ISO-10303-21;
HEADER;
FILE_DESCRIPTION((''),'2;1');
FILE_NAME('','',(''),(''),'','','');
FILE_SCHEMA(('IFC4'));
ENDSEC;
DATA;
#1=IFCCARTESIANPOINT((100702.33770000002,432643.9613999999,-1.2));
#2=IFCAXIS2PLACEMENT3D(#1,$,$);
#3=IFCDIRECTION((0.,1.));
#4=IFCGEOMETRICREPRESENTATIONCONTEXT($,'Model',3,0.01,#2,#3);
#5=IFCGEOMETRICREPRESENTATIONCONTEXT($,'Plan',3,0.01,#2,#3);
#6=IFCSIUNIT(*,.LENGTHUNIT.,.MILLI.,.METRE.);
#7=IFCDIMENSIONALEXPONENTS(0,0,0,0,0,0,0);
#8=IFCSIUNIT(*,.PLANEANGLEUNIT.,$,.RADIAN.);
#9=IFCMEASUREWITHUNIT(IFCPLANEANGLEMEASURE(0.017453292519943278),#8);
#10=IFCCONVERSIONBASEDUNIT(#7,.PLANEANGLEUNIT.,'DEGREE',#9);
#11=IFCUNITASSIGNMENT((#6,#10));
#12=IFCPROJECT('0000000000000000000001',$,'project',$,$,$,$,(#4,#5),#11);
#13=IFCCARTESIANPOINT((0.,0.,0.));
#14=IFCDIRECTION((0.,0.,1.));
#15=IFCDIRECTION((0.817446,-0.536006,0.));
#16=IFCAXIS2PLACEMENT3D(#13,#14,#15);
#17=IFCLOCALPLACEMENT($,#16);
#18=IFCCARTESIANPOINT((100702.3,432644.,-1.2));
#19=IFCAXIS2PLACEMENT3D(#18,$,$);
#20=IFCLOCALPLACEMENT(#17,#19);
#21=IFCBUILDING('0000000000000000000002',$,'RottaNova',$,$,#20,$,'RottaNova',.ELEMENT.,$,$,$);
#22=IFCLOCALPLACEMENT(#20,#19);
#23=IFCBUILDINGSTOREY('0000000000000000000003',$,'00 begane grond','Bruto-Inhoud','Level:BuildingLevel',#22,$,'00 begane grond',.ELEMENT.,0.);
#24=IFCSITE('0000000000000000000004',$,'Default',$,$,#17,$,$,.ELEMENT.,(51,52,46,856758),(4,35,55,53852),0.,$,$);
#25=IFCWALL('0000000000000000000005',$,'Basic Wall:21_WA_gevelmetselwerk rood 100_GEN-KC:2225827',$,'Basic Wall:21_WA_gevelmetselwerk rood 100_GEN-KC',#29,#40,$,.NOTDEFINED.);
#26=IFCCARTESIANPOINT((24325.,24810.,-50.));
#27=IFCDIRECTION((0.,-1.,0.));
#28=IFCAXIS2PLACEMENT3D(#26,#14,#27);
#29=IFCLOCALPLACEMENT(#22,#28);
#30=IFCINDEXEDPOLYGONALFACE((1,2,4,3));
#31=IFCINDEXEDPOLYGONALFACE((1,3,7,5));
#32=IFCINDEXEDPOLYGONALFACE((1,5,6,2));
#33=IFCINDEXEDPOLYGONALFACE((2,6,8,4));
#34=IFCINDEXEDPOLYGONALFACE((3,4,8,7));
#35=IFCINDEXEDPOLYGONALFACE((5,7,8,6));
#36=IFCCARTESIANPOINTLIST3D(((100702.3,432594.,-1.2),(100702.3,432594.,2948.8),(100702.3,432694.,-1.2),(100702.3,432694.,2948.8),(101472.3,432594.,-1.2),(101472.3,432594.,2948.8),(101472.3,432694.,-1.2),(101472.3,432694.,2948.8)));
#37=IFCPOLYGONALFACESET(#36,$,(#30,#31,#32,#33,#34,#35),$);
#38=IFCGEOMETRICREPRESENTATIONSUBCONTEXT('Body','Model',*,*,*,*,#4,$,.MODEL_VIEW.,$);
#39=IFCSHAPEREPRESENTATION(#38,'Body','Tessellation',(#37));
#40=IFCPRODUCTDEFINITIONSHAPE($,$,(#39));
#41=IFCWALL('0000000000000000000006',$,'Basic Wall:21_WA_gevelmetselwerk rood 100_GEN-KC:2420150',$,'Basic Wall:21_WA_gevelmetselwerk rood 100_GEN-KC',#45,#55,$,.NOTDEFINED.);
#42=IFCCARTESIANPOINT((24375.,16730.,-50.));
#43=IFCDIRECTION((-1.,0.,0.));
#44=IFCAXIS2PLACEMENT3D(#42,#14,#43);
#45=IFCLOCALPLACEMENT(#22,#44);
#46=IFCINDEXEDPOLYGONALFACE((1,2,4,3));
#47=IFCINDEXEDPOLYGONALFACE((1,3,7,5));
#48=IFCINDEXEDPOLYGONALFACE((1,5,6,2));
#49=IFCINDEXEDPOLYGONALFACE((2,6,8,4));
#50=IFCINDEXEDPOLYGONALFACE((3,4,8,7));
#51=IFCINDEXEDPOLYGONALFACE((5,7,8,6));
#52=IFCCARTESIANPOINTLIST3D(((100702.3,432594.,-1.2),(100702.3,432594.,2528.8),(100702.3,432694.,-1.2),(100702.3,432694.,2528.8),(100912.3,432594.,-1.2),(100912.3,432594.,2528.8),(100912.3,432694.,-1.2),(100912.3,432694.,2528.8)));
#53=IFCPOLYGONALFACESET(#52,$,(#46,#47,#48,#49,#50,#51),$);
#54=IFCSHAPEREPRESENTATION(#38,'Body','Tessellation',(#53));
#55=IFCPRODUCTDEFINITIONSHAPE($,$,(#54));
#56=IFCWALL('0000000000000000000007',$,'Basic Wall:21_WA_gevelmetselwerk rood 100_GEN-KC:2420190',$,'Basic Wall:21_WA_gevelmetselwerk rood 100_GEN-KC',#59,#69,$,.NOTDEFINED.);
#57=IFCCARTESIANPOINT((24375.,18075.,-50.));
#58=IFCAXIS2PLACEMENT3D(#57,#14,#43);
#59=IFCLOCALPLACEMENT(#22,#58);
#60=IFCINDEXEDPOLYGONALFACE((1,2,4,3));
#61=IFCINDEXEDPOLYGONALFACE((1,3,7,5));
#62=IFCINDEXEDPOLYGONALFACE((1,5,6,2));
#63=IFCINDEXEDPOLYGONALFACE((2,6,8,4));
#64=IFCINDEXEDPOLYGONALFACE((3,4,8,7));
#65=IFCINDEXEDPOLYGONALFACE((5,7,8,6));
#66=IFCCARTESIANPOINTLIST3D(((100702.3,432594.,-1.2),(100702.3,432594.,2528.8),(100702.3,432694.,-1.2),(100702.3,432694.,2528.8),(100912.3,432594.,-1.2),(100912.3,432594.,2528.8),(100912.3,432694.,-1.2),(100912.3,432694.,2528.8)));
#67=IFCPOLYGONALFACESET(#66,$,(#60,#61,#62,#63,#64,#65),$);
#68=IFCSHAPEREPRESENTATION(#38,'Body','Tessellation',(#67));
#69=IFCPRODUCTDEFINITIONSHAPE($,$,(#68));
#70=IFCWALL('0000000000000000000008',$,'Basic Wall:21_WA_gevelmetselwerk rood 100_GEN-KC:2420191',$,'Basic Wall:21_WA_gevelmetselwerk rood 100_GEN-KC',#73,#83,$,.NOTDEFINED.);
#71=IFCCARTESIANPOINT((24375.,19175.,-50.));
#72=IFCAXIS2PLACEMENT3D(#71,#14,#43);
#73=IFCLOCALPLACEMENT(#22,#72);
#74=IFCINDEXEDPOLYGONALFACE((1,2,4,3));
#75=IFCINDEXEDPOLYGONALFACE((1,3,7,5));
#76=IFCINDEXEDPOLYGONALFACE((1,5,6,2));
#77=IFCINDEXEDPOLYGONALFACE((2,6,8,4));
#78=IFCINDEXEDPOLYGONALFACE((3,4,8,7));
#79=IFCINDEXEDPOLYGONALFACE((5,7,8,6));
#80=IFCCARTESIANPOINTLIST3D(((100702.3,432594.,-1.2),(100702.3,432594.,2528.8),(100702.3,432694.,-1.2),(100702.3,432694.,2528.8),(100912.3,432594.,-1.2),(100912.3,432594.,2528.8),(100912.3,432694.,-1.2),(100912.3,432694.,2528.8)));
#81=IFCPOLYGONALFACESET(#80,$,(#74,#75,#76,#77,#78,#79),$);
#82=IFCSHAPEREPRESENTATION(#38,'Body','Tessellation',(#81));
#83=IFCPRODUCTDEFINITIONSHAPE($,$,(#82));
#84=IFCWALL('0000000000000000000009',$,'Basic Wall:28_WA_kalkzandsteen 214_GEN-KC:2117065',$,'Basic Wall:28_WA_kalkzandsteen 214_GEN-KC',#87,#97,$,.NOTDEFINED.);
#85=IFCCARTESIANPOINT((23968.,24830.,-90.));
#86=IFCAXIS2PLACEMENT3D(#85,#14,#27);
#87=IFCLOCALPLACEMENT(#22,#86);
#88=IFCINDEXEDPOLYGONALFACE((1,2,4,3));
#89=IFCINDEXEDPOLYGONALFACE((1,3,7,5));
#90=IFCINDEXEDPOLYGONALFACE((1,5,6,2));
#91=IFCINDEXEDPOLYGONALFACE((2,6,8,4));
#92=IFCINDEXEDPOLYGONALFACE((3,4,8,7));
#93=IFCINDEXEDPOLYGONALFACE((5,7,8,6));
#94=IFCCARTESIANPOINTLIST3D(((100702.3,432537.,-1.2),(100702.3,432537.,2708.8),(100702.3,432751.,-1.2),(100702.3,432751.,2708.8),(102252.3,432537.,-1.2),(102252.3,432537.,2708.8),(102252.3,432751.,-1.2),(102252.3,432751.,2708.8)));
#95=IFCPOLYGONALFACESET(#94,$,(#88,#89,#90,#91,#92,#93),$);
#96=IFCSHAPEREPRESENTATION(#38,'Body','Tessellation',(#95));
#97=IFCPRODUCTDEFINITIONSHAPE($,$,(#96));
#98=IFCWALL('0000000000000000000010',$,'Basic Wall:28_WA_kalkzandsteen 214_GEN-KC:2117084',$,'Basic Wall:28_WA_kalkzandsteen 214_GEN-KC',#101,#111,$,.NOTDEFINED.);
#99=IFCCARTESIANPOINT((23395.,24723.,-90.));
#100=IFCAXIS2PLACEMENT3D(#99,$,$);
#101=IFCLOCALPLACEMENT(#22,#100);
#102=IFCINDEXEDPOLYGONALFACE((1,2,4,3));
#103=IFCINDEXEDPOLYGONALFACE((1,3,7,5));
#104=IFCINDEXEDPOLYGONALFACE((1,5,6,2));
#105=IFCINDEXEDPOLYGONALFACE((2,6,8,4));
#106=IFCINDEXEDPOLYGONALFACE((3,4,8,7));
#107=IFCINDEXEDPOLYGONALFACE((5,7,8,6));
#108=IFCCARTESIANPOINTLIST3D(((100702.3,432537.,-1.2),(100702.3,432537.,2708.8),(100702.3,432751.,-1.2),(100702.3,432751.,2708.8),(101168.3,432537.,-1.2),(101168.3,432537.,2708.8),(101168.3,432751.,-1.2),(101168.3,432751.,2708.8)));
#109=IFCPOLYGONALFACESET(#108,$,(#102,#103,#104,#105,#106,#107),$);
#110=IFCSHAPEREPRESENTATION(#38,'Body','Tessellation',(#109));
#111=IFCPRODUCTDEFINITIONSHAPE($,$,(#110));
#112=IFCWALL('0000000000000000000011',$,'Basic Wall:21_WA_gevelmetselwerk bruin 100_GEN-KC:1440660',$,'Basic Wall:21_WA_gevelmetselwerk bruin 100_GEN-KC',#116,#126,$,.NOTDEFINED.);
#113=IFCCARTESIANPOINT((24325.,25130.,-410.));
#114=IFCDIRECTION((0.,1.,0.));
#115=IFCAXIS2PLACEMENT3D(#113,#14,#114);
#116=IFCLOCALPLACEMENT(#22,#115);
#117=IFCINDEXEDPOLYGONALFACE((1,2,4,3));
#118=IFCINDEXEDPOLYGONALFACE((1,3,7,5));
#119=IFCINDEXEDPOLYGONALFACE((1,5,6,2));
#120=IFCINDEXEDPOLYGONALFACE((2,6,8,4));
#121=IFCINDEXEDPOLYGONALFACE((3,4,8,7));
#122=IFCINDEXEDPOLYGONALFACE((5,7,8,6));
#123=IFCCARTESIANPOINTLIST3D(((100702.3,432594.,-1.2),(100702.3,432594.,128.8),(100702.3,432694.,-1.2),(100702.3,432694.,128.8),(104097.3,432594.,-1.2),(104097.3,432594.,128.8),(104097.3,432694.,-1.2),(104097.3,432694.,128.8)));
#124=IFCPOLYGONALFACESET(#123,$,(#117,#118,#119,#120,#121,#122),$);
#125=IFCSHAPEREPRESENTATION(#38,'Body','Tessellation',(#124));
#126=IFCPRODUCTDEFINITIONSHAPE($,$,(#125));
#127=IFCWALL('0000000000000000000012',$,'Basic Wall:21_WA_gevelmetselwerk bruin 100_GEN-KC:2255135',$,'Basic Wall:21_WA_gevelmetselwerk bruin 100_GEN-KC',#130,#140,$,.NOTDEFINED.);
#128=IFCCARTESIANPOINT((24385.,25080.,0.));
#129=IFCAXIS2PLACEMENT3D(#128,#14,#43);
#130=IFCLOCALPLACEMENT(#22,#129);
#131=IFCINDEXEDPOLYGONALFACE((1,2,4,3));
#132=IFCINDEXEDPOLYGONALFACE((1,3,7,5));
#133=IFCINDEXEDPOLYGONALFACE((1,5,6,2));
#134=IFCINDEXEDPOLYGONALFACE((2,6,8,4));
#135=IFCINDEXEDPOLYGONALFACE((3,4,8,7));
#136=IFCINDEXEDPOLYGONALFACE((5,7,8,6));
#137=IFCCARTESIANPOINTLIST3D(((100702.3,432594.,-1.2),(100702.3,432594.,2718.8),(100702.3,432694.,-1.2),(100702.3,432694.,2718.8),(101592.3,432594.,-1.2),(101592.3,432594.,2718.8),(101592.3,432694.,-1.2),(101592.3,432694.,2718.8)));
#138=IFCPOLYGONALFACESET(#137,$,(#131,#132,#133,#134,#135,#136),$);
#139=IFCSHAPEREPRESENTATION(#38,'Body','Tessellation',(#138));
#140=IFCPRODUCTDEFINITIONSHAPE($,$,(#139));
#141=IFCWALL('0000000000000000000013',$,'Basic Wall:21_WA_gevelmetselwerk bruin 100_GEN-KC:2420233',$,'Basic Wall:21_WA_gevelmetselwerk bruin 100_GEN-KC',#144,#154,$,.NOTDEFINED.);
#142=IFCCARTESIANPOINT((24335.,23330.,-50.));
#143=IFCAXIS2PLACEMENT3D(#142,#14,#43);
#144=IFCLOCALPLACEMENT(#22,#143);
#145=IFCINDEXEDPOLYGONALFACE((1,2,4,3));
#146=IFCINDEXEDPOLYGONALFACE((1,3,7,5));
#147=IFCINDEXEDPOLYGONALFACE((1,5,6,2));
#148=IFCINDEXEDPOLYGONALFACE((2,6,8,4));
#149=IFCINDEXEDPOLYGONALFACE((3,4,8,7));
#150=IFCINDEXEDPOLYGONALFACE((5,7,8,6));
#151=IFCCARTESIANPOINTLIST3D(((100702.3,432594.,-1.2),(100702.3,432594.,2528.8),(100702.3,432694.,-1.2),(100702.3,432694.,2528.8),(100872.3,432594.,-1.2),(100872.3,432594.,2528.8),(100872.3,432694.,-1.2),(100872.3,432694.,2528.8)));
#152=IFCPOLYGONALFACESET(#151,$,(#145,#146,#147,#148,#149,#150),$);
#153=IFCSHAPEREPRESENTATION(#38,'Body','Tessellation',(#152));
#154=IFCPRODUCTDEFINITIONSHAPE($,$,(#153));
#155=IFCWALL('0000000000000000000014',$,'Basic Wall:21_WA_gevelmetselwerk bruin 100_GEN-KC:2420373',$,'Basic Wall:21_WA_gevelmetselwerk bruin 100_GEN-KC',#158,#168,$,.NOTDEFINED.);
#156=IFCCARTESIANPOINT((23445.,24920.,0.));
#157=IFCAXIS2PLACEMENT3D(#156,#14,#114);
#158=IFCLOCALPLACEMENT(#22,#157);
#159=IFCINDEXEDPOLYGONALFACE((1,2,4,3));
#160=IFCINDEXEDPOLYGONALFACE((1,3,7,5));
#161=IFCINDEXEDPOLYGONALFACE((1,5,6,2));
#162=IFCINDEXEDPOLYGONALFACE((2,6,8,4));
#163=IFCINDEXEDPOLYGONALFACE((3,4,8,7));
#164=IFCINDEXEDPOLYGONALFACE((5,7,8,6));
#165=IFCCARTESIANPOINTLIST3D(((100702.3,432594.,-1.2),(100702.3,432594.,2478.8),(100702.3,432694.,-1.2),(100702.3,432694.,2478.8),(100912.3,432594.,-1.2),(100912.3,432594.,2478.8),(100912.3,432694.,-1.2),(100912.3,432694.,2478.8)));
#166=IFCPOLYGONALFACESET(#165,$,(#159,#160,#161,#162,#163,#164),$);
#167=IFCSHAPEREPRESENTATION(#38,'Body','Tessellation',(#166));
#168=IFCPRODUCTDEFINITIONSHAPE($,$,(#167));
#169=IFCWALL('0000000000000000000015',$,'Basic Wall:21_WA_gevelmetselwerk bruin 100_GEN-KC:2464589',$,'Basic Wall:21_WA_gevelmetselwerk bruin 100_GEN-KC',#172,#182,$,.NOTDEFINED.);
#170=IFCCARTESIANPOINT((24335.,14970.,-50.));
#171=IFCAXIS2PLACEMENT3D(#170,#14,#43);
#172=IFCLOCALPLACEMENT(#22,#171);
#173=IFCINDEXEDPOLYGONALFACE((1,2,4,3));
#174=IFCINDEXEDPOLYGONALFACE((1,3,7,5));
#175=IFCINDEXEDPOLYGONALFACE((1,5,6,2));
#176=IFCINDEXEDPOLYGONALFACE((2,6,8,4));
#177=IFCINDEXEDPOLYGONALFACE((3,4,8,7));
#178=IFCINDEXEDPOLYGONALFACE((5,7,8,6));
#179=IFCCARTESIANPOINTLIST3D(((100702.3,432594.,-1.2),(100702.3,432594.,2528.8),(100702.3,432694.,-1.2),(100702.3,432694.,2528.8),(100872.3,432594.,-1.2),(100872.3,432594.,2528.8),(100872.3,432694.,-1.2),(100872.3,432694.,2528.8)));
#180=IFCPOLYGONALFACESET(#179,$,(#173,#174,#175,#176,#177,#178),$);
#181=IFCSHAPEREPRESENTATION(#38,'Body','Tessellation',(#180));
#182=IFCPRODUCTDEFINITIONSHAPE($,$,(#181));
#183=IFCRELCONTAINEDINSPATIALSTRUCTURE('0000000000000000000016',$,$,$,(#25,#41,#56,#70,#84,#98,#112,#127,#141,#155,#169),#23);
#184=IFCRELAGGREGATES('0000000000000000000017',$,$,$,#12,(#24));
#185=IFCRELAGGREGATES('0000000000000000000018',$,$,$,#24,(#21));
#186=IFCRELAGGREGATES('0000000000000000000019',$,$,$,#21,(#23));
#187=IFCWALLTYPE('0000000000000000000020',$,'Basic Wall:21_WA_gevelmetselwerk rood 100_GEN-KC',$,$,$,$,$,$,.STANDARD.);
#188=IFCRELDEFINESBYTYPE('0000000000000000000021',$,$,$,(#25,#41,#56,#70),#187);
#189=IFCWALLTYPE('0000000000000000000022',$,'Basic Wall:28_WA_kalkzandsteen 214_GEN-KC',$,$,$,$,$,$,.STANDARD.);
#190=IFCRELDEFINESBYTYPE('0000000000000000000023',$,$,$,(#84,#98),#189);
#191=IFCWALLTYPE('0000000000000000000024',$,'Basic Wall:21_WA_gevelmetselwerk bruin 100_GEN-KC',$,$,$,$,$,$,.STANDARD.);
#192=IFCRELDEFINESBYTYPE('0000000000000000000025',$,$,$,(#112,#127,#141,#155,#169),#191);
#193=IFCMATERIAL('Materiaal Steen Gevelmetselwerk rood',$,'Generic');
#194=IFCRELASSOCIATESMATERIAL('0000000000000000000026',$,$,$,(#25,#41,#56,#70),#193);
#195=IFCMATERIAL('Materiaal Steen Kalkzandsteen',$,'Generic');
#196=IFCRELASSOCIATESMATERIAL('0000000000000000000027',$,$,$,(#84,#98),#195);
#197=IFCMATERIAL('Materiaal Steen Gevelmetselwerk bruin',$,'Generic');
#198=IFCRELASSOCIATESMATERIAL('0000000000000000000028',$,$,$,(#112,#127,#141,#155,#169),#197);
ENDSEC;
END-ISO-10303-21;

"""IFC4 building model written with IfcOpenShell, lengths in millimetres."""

from ifc_helpers import new_model, entity, si_unit, converted_unit, direction, frame, place, context, subcontext, project, spatial, indexed_curve, outline, extrude, material, type_object, element, save


model = new_model("IFC4")

# Units and contexts
model_context = context("Model", 3, precision=0.01, world=frame((100702.33770000002, 432643.9613999999, -1.2)), true_north=direction((0.0, 1.0)))
plan_context = context("Plan", 3, precision=0.01, world=frame((100702.33770000002, 432643.9613999999, -1.2)), true_north=direction((0.0, 1.0)))
body_context = subcontext(model_context, "Body", "Model", "MODEL_VIEW")
ifc_project = project(units=[si_unit("LENGTHUNIT", "METRE", prefix="MILLI"), converted_unit("PLANEANGLEUNIT", "DEGREE", entity("IfcPlaneAngleMeasure", 0.017453292519943278), si_unit("PLANEANGLEUNIT", "RADIAN"), dimensions=[0, 0, 0, 0, 0, 0, 0])], contexts=[model_context, plan_context])

# Site, building, storey
site_placement = place(None, frame((0.0, 0.0, 0.0), z_axis=(0.0, 0.0, 1.0), x_axis=(0.817446, -0.536006, 0.0)))
site = spatial("IfcSite", under=ifc_project, at=site_placement, Name="Default", CompositionType="ELEMENT", RefLatitude=(51, 52, 46, 856758), RefLongitude=(4, 35, 55, 53852), RefElevation=0.0)
building_placement = place(site_placement, frame((100702.3, 432644.0, -1.2)))
building = spatial("IfcBuilding", under=site, at=building_placement, Name="RottaNova", LongName="RottaNova", CompositionType="ELEMENT")
storey_placement = place(building_placement, frame((100702.3, 432644.0, -1.2)))
storey = spatial("IfcBuildingStorey", under=building, at=storey_placement, Name="00 begane grond", Description="Bruto-Inhoud", ObjectType="Level:BuildingLevel", LongName="00 begane grond", CompositionType="ELEMENT", Elevation=0.0)

# Walls
ifc_material_1 = material(Name="Materiaal Steen Gevelmetselwerk rood", Category="Generic")
wall_type_1 = type_object("IfcWallType", Name="Basic Wall:21_WA_gevelmetselwerk rood 100_GEN-KC", PredefinedType="STANDARD")
wall_1_placement = place(storey_placement, frame((24325.0, 24810.0, -50.0), z_axis=(0.0, 0.0, 1.0), x_axis=(0.0, -1.0, 0.0)))
element("IfcWall", 1, at=wall_1_placement, inside=storey, type_object=wall_type_1, material=ifc_material_1, Name="Basic Wall:21_WA_gevelmetselwerk rood 100_GEN-KC:2225827", ObjectType="Basic Wall:21_WA_gevelmetselwerk rood 100_GEN-KC", PredefinedType="NOTDEFINED", context=body_context, shape_type="SweptSolid", body=[
    extrude(outline(indexed_curve([(770.0, 50.0), (0.0, 50.0), (0.0, -50.0), (770.0, -50.0), (770.0, 50.0)], self_intersect=False)), frame((100702.3, 432644.0, -1.2)), (0.0, 0.0, 1.0), 2950.0),
])
wall_2_placement = place(storey_placement, frame((24375.0, 16730.0, -50.0), z_axis=(0.0, 0.0, 1.0), x_axis=(-1.0, 0.0, 0.0)))
element("IfcWall", 2, at=wall_2_placement, inside=storey, type_object=wall_type_1, material=ifc_material_1, Name="Basic Wall:21_WA_gevelmetselwerk rood 100_GEN-KC:2420150", ObjectType="Basic Wall:21_WA_gevelmetselwerk rood 100_GEN-KC", PredefinedType="NOTDEFINED", context=body_context, shape_type="SweptSolid", body=[
    extrude(outline(indexed_curve([(210.0, 50.0), (0.0, 50.0), (0.0, -50.0), (210.0, -50.0), (210.0, 50.0)], self_intersect=False)), frame((100702.3, 432644.0, -1.2)), (0.0, 0.0, 1.0), 2530.0),
])
wall_3_placement = place(storey_placement, frame((24375.0, 18075.0, -50.0), z_axis=(0.0, 0.0, 1.0), x_axis=(-1.0, 0.0, 0.0)))
element("IfcWall", 3, at=wall_3_placement, inside=storey, type_object=wall_type_1, material=ifc_material_1, Name="Basic Wall:21_WA_gevelmetselwerk rood 100_GEN-KC:2420190", ObjectType="Basic Wall:21_WA_gevelmetselwerk rood 100_GEN-KC", PredefinedType="NOTDEFINED", context=body_context, shape_type="SweptSolid", body=[
    extrude(outline(indexed_curve([(210.0, 50.0), (0.0, 50.0), (0.0, -50.0), (210.0, -50.0), (210.0, 50.0)], self_intersect=False)), frame((100702.3, 432644.0, -1.2)), (0.0, 0.0, 1.0), 2530.0),
])
wall_4_placement = place(storey_placement, frame((24375.0, 19175.0, -50.0), z_axis=(0.0, 0.0, 1.0), x_axis=(-1.0, 0.0, 0.0)))
element("IfcWall", 4, at=wall_4_placement, inside=storey, type_object=wall_type_1, material=ifc_material_1, Name="Basic Wall:21_WA_gevelmetselwerk rood 100_GEN-KC:2420191", ObjectType="Basic Wall:21_WA_gevelmetselwerk rood 100_GEN-KC", PredefinedType="NOTDEFINED", context=body_context, shape_type="SweptSolid", body=[
    extrude(outline(indexed_curve([(210.0, 50.0), (0.0, 50.0), (0.0, -50.0), (210.0, -50.0), (210.0, 50.0)], self_intersect=False)), frame((100702.3, 432644.0, -1.2)), (0.0, 0.0, 1.0), 2530.0),
])
ifc_material_2 = material(Name="Materiaal Steen Kalkzandsteen", Category="Generic")
wall_type_2 = type_object("IfcWallType", Name="Basic Wall:28_WA_kalkzandsteen 214_GEN-KC", PredefinedType="STANDARD")
wall_5_placement = place(storey_placement, frame((23968.0, 24830.0, -90.0), z_axis=(0.0, 0.0, 1.0), x_axis=(0.0, -1.0, 0.0)))
element("IfcWall", 5, at=wall_5_placement, inside=storey, type_object=wall_type_2, material=ifc_material_2, Name="Basic Wall:28_WA_kalkzandsteen 214_GEN-KC:2117065", ObjectType="Basic Wall:28_WA_kalkzandsteen 214_GEN-KC", PredefinedType="NOTDEFINED", context=body_context, shape_type="SweptSolid", body=[
    extrude(outline(indexed_curve([(1550.0, 107.0), (0.0, 107.0), (0.0, -107.0), (1550.0, -107.0), (1550.0, 107.0)], self_intersect=False)), frame((100702.3, 432644.0, -1.2)), (0.0, 0.0, 1.0), 2710.0),
])
wall_6_placement = place(storey_placement, frame((23395.0, 24723.0, -90.0)))
element("IfcWall", 6, at=wall_6_placement, inside=storey, type_object=wall_type_2, material=ifc_material_2, Name="Basic Wall:28_WA_kalkzandsteen 214_GEN-KC:2117084", ObjectType="Basic Wall:28_WA_kalkzandsteen 214_GEN-KC", PredefinedType="NOTDEFINED", context=body_context, shape_type="SweptSolid", body=[
    extrude(outline(indexed_curve([(466.0, 107.0), (0.0, 107.0), (0.0, -107.0), (466.0, -107.0), (466.0, 107.0)], self_intersect=False)), frame((100702.3, 432644.0, -1.2)), (0.0, 0.0, 1.0), 2710.0),
])
ifc_material_3 = material(Name="Materiaal Steen Gevelmetselwerk bruin", Category="Generic")
wall_type_3 = type_object("IfcWallType", Name="Basic Wall:21_WA_gevelmetselwerk bruin 100_GEN-KC", PredefinedType="STANDARD")
wall_7_placement = place(storey_placement, frame((24325.0, 25130.0, -410.0), z_axis=(0.0, 0.0, 1.0), x_axis=(0.0, 1.0, 0.0)))
element("IfcWall", 7, at=wall_7_placement, inside=storey, type_object=wall_type_3, material=ifc_material_3, Name="Basic Wall:21_WA_gevelmetselwerk bruin 100_GEN-KC:1440660", ObjectType="Basic Wall:21_WA_gevelmetselwerk bruin 100_GEN-KC", PredefinedType="NOTDEFINED", context=body_context, shape_type="SweptSolid", body=[
    extrude(outline(indexed_curve([(3395.0, 50.0), (0.0, 50.0), (0.0, -50.0), (3395.0, -50.0), (3395.0, 50.0)], self_intersect=False)), frame((100702.3, 432644.0, -1.2)), (0.0, 0.0, 1.0), 130.0),
])
wall_8_placement = place(storey_placement, frame((24385.0, 25080.0, 0.0), z_axis=(0.0, 0.0, 1.0), x_axis=(-1.0, 0.0, 0.0)))
element("IfcWall", 8, at=wall_8_placement, inside=storey, type_object=wall_type_3, material=ifc_material_3, Name="Basic Wall:21_WA_gevelmetselwerk bruin 100_GEN-KC:2255135", ObjectType="Basic Wall:21_WA_gevelmetselwerk bruin 100_GEN-KC", PredefinedType="NOTDEFINED", context=body_context, shape_type="SweptSolid", body=[
    extrude(outline(indexed_curve([(890.0, 50.0), (0.0, 50.0), (0.0, -50.0), (890.0, -50.0), (890.0, 50.0)], self_intersect=False)), frame((100702.3, 432644.0, -1.2)), (0.0, 0.0, 1.0), 2720.0),
])
wall_9_placement = place(storey_placement, frame((24335.0, 23330.0, -50.0), z_axis=(0.0, 0.0, 1.0), x_axis=(-1.0, 0.0, 0.0)))
element("IfcWall", 9, at=wall_9_placement, inside=storey, type_object=wall_type_3, material=ifc_material_3, Name="Basic Wall:21_WA_gevelmetselwerk bruin 100_GEN-KC:2420233", ObjectType="Basic Wall:21_WA_gevelmetselwerk bruin 100_GEN-KC", PredefinedType="NOTDEFINED", context=body_context, shape_type="SweptSolid", body=[
    extrude(outline(indexed_curve([(170.0, 50.0), (0.0, 50.0), (0.0, -50.0), (170.0, -50.0), (170.0, 50.0)], self_intersect=False)), frame((100702.3, 432644.0, -1.2)), (0.0, 0.0, 1.0), 2530.0),
])
wall_10_placement = place(storey_placement, frame((23445.0, 24920.0, 0.0), z_axis=(0.0, 0.0, 1.0), x_axis=(0.0, 1.0, 0.0)))
element("IfcWall", 10, at=wall_10_placement, inside=storey, type_object=wall_type_3, material=ifc_material_3, Name="Basic Wall:21_WA_gevelmetselwerk bruin 100_GEN-KC:2420373", ObjectType="Basic Wall:21_WA_gevelmetselwerk bruin 100_GEN-KC", PredefinedType="NOTDEFINED", context=body_context, shape_type="SweptSolid", body=[
    extrude(outline(indexed_curve([(210.0, 50.0), (0.0, 50.0), (0.0, -50.0), (210.0, -50.0), (210.0, 50.0)], self_intersect=False)), frame((100702.3, 432644.0, -1.2)), (0.0, 0.0, 1.0), 2480.0),
])
wall_11_placement = place(storey_placement, frame((24335.0, 14970.0, -50.0), z_axis=(0.0, 0.0, 1.0), x_axis=(-1.0, 0.0, 0.0)))
element("IfcWall", 11, at=wall_11_placement, inside=storey, type_object=wall_type_3, material=ifc_material_3, Name="Basic Wall:21_WA_gevelmetselwerk bruin 100_GEN-KC:2464589", ObjectType="Basic Wall:21_WA_gevelmetselwerk bruin 100_GEN-KC", PredefinedType="NOTDEFINED", context=body_context, shape_type="SweptSolid", body=[
    extrude(outline(indexed_curve([(170.0, 50.0), (0.0, 50.0), (0.0, -50.0), (170.0, -50.0), (170.0, 50.0)], self_intersect=False)), frame((100702.3, 432644.0, -1.2)), (0.0, 0.0, 1.0), 2530.0),
])

save(model, "model.ifc")
